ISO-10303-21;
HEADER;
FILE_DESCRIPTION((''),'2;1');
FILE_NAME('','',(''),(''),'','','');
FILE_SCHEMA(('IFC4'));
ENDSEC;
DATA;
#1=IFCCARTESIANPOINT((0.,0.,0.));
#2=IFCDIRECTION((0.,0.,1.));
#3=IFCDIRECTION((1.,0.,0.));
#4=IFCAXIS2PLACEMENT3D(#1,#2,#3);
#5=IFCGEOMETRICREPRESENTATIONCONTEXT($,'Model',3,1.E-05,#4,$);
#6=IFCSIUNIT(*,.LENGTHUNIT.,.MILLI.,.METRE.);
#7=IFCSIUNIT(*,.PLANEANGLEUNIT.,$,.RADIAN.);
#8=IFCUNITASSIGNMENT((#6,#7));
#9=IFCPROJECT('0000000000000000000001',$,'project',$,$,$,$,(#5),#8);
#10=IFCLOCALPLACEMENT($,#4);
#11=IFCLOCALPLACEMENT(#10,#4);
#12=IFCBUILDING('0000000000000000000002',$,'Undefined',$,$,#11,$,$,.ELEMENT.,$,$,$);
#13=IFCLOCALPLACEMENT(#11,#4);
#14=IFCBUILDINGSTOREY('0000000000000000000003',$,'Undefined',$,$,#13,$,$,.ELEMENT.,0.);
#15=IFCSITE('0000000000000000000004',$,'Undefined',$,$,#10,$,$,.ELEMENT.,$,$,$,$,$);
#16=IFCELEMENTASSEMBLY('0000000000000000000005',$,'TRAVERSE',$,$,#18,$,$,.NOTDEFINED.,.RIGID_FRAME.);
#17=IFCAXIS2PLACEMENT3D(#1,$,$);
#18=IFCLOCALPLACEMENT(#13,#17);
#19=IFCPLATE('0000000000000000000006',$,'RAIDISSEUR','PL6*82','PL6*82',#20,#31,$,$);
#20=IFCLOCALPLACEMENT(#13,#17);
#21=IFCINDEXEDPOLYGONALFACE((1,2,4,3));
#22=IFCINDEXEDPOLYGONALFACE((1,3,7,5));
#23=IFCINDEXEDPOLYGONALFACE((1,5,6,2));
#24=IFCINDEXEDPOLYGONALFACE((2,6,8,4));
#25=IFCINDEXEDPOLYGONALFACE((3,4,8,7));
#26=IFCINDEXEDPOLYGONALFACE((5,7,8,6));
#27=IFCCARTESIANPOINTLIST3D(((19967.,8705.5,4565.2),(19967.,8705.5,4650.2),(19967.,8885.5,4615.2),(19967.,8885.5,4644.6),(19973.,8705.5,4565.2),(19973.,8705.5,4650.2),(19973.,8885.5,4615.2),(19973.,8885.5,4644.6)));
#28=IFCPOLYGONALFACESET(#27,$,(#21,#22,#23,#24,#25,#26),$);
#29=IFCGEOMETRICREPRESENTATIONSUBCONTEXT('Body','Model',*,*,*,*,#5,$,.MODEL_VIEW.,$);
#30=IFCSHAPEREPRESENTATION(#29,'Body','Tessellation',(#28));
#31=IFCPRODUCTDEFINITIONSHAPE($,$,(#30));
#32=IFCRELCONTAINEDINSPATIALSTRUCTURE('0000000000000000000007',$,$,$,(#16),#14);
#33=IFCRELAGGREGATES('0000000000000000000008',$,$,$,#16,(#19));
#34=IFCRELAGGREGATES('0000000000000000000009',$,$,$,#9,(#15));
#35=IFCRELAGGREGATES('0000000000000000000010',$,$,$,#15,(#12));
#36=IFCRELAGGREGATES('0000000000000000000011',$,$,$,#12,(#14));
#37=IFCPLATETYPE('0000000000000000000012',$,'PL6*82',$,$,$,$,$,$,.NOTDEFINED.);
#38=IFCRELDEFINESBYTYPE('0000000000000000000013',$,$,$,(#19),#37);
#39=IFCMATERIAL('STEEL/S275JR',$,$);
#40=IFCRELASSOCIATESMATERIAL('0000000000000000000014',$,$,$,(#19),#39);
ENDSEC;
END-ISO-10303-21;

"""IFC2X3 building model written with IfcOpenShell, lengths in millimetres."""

from ifc_helpers import new_model, si_unit, frame, origin_with_axes, place, context, subcontext, project, spatial, polyline, outline, extrude, material, type_object, element, aggregate, save


model = new_model("IFC2X3")

# Units and contexts
model_context = context("Model", 3, precision=1e-05, world=origin_with_axes())
body_context = subcontext(model_context, "Body", "Model", "MODEL_VIEW")
ifc_project = project(units=[si_unit("LENGTHUNIT", "METRE", prefix="MILLI"), si_unit("PLANEANGLEUNIT", "RADIAN")], contexts=[model_context])

# Site, building, storey
site_placement = place(None, origin_with_axes())
site = spatial("IfcSite", under=ifc_project, at=site_placement, Name="Undefined", CompositionType="ELEMENT")
building_placement = place(site_placement, origin_with_axes())
building = spatial("IfcBuilding", under=site, at=building_placement, Name="Undefined", CompositionType="ELEMENT")
storey_placement = place(building_placement, origin_with_axes())
storey = spatial("IfcBuildingStorey", under=building, at=storey_placement, Name="Undefined", CompositionType="ELEMENT", Elevation=0.0)

# Shared definitions
ifc_material_1 = material(Name="STEEL/S275JR")

# Element assembly
assembly_1_placement = place(storey_placement, origin_with_axes())
assembly_1 = element("IfcElementAssembly", 1, at=assembly_1_placement, inside=storey, Name="TRAVERSE", AssemblyPlace="NOTDEFINED", PredefinedType="RIGID_FRAME")

# Plate
plate_type_1 = type_object("IfcPlateType", Name="PL6*82", PredefinedType="NOTDEFINED")
plate_1_placement = place(assembly_1_placement, frame((19970.0, 8705.5, 4650.2), z_axis=(1.0, 0.0, 0.0), x_axis=(0.0, 0.0, -1.0)))
plate_1 = element("IfcPlate", 2, at=plate_1_placement, type_object=plate_type_1, material=ifc_material_1, Name="RAIDISSEUR", Description="PL6*82", ObjectType="PL6*82", context=body_context, shape_type="SweptSolid", body=[
    extrude(outline(polyline([(0.0, 0.0), (85.0, 0.0), (35.0, 180.0), (5.6, 180.0), (0.0, 0.0)])), frame((0.0, 0.0, -3.0), z_axis=(0.0, 0.0, 1.0), x_axis=(1.0, 0.0, 0.0)), (0.0, 0.0, 1.0), 6.0),
])

aggregate(assembly_1, [plate_1])

save(model, "model.ifc")
